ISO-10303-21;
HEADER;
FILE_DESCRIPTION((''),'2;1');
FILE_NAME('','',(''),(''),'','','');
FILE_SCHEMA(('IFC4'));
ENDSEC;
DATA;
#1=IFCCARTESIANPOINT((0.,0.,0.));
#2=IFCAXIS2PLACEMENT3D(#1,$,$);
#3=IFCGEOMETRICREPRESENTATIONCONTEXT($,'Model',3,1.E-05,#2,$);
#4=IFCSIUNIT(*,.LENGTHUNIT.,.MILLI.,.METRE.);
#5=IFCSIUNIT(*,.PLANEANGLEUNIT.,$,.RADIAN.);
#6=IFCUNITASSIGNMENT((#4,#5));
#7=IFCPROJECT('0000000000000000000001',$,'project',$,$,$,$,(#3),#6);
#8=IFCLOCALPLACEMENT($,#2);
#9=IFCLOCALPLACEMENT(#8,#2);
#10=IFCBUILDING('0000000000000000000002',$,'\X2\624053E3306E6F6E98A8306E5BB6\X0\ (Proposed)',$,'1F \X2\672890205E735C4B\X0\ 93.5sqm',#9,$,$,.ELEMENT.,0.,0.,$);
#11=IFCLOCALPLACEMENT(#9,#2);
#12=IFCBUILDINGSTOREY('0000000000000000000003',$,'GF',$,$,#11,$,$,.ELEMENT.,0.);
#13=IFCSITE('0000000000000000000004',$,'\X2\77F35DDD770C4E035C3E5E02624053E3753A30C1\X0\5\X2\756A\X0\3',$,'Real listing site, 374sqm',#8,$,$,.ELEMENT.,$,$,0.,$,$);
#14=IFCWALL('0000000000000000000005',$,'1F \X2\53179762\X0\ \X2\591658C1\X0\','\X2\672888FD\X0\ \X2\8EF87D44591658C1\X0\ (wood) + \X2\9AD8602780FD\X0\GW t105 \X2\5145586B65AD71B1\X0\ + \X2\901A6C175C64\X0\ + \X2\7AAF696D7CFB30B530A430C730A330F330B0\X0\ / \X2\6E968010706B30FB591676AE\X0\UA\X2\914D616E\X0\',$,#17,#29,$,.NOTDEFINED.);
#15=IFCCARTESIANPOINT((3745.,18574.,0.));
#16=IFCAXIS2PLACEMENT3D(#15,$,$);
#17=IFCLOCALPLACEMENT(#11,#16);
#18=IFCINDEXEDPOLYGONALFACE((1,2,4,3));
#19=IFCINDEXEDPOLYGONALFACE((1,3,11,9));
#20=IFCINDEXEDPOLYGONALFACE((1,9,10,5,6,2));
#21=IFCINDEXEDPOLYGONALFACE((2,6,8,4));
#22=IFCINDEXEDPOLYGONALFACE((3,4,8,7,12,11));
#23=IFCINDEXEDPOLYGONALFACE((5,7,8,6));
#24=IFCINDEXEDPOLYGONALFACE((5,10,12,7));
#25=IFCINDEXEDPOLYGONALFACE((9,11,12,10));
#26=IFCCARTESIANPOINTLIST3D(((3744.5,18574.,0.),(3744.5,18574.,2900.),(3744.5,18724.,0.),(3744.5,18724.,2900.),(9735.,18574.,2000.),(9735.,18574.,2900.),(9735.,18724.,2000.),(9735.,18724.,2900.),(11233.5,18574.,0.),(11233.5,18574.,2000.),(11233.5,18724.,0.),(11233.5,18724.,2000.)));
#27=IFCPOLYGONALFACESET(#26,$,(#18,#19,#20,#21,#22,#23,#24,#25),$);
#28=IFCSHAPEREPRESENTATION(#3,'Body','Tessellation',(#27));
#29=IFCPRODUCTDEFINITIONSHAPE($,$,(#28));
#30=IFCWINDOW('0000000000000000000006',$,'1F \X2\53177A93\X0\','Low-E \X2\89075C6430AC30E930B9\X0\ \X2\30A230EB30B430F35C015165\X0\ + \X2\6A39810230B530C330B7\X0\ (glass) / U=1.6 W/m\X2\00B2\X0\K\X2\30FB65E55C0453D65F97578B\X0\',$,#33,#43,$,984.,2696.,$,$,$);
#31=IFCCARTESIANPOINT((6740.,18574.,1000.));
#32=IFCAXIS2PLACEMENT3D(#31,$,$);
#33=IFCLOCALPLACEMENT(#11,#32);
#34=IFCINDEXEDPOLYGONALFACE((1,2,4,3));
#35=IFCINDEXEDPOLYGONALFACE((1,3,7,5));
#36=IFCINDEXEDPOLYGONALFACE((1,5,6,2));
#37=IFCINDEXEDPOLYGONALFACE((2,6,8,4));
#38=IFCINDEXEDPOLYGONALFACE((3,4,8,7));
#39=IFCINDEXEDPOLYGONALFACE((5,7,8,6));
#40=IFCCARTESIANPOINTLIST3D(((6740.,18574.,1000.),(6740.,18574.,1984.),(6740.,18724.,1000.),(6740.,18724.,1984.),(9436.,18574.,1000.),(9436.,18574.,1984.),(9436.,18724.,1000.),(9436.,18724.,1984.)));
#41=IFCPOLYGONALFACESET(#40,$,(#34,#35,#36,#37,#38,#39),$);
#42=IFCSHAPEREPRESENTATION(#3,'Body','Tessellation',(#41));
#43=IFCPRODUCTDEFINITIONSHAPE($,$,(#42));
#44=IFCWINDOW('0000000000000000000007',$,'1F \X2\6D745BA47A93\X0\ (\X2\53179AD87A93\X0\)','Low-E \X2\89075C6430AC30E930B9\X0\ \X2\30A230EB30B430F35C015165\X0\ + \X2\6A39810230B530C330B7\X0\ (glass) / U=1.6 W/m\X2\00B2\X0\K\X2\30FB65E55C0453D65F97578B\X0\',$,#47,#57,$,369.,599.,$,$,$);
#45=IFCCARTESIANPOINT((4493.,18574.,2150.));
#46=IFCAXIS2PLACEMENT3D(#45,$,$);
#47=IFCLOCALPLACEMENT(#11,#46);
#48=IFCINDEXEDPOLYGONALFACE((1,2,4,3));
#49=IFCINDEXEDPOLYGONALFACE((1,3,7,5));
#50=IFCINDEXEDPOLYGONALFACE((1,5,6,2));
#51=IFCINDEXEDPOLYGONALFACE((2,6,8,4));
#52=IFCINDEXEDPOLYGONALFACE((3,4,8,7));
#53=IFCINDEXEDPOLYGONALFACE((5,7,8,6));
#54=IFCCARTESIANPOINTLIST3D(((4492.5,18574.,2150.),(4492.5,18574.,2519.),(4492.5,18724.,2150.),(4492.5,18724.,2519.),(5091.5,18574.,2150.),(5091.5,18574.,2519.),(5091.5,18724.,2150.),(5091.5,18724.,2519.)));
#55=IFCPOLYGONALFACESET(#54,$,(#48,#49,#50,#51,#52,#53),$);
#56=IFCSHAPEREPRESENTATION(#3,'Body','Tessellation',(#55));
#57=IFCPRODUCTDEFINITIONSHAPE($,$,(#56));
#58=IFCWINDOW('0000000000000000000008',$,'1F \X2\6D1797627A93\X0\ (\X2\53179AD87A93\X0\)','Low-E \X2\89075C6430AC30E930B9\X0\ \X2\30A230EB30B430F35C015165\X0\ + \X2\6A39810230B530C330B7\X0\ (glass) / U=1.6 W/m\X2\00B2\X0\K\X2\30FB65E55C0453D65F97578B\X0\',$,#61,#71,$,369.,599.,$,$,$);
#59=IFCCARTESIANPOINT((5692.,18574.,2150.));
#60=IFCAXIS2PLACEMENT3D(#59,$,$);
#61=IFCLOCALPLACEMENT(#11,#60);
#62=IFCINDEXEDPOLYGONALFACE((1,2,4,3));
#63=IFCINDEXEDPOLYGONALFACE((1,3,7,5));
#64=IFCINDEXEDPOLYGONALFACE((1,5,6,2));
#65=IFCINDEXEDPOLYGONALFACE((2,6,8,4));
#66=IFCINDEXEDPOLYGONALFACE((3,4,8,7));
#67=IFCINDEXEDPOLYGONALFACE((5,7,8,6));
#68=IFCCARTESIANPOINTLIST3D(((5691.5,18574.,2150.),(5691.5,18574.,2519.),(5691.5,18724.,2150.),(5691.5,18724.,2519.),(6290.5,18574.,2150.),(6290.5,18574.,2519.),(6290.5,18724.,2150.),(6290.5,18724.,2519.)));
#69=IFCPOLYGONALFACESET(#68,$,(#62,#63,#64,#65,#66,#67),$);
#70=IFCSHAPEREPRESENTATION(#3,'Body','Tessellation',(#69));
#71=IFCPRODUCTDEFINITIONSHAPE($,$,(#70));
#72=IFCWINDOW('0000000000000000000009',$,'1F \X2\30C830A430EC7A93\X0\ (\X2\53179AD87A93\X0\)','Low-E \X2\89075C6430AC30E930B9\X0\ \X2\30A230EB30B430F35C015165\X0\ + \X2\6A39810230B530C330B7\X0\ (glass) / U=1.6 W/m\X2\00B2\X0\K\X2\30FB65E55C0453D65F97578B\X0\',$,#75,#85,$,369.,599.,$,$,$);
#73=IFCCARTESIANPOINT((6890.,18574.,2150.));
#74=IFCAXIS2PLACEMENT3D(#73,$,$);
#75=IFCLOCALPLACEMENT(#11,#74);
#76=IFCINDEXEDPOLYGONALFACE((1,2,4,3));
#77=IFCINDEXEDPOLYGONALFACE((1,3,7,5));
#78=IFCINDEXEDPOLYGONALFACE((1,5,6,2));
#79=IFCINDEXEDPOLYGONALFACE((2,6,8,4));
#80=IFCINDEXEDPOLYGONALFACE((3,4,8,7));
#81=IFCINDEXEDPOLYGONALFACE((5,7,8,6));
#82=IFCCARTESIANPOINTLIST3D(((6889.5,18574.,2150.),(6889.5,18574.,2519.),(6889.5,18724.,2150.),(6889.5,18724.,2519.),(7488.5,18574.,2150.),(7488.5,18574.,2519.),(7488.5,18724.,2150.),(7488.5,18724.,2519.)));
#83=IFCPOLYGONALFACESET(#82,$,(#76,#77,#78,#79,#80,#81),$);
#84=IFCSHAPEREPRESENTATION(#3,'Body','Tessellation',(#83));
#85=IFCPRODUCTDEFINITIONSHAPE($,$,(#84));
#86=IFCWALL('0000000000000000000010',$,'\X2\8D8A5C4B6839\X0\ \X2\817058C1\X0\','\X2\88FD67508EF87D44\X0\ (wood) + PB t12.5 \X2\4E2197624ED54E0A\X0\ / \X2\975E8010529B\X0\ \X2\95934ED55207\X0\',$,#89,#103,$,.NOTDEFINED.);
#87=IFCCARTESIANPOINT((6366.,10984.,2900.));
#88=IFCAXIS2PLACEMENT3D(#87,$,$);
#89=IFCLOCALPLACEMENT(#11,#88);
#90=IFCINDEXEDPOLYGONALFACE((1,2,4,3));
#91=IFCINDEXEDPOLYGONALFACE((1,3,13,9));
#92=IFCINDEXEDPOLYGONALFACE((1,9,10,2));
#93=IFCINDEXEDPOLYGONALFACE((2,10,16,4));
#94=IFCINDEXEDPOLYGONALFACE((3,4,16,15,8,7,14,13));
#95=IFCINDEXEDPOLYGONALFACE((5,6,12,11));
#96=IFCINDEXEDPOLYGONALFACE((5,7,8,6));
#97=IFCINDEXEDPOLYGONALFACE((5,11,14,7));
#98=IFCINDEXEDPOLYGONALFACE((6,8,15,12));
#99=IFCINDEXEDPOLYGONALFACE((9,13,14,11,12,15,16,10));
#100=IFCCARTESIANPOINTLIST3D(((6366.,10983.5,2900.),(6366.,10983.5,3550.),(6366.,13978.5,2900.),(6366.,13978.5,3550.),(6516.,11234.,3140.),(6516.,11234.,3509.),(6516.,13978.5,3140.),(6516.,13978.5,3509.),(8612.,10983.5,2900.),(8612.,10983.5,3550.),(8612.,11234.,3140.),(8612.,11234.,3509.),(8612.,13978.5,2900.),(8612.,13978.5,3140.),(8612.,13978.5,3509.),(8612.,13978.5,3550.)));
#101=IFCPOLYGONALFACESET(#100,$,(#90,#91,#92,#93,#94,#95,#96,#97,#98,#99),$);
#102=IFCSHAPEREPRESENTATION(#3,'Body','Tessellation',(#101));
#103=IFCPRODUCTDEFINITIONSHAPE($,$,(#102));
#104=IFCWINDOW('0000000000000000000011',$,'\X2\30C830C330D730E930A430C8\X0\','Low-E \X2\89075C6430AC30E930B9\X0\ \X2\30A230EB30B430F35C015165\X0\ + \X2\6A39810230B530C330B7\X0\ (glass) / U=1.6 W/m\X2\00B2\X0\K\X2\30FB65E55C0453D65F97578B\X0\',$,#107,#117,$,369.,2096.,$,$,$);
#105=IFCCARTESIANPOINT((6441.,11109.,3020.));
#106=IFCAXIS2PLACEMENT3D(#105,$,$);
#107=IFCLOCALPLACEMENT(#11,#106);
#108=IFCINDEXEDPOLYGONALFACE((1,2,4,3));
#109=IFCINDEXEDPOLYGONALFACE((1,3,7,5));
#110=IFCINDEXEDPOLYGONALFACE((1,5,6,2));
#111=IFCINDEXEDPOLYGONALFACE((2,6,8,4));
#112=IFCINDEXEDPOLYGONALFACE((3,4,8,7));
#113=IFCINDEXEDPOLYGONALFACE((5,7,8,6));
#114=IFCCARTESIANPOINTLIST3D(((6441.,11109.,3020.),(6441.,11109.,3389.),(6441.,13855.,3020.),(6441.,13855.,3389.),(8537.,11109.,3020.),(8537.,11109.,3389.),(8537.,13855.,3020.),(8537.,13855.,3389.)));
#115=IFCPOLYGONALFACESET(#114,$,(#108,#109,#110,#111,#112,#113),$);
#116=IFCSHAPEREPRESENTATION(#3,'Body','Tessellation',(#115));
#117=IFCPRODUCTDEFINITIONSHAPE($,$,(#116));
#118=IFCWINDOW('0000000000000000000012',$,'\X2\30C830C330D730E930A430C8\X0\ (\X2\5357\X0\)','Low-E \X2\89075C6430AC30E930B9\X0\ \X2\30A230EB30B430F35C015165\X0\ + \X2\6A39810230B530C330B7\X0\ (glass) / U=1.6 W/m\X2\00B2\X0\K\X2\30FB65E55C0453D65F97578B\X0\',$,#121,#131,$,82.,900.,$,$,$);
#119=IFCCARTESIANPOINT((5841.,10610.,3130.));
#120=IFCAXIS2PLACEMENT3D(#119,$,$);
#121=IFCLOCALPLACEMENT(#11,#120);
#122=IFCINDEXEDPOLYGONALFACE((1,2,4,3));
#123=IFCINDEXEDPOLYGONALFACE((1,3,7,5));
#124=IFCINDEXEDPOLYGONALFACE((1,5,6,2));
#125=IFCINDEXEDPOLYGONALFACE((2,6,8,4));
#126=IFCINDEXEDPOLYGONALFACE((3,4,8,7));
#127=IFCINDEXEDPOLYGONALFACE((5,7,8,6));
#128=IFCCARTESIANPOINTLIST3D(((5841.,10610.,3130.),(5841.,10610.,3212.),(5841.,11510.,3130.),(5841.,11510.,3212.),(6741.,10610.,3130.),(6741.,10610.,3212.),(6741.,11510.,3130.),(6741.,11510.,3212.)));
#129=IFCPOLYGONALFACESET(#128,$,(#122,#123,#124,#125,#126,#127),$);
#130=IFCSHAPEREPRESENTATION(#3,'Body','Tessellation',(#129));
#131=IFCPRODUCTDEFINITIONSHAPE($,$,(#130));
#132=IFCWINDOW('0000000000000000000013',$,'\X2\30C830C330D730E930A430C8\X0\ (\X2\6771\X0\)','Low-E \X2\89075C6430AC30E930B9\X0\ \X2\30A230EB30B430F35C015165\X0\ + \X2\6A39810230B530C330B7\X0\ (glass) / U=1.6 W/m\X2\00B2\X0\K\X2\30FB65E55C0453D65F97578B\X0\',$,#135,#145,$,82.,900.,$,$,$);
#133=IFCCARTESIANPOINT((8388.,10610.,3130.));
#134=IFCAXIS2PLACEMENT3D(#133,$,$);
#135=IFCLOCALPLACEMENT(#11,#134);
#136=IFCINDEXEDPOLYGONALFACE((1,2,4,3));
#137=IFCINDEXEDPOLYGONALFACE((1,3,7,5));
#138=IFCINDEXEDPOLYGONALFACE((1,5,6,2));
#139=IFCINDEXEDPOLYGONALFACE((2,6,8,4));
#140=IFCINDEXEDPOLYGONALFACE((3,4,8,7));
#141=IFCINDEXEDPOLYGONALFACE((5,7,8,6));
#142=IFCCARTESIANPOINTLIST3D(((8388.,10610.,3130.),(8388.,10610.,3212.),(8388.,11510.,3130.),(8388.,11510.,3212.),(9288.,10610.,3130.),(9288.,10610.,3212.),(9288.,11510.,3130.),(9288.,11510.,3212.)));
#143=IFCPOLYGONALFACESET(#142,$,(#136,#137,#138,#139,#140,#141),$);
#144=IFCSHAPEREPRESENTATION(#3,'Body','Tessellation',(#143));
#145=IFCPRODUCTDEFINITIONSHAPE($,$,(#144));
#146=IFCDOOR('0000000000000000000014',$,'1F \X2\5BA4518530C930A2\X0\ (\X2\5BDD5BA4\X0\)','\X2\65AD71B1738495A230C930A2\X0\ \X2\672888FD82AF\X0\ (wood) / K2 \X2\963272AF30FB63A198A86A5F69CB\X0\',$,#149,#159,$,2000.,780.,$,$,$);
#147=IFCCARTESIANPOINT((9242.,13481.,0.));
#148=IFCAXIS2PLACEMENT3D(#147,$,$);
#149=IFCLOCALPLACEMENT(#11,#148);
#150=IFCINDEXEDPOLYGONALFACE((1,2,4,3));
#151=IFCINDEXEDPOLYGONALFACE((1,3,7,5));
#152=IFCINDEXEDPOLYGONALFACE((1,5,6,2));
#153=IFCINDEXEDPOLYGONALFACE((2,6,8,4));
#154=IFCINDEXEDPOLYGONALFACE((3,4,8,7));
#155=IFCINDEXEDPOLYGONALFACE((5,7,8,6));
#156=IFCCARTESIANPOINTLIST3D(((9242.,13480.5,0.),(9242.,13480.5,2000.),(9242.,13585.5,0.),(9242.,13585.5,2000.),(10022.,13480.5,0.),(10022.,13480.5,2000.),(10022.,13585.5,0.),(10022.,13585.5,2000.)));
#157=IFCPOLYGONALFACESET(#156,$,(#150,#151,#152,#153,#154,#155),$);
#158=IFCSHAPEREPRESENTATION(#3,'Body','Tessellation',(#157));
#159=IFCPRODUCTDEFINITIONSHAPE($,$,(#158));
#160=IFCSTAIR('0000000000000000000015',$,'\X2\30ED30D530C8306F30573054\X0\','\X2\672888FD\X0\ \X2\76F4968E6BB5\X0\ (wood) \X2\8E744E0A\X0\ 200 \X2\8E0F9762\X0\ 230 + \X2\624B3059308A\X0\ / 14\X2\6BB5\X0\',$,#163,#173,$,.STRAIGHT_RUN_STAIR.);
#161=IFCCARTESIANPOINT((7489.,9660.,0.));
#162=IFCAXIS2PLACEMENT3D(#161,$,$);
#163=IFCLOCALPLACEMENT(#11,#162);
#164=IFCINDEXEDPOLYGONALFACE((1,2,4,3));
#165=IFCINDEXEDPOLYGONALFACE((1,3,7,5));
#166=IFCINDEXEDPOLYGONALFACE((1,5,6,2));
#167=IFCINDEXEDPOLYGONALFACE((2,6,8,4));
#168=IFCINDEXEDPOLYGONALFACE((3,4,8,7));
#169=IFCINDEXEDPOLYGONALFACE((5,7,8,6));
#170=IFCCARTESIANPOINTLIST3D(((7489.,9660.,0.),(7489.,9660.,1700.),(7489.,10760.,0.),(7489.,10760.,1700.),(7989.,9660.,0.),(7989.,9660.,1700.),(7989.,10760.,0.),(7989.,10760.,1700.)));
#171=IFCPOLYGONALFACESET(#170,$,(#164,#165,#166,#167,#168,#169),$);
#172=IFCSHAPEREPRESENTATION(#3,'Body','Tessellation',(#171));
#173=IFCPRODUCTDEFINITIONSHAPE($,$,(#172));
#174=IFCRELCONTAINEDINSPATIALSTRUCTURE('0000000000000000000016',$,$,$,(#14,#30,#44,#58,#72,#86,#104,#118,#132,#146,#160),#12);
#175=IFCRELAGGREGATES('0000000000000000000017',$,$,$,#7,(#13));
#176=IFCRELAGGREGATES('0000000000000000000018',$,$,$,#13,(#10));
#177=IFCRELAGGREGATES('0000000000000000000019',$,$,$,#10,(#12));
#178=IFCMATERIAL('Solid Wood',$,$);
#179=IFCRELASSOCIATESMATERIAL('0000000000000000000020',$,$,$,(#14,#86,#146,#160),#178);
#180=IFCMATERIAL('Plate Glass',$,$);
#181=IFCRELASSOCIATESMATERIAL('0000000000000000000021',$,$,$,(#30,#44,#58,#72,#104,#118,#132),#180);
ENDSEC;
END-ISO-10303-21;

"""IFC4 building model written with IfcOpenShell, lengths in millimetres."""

from ifc_helpers import new_model, si_unit, frame, frame_2d, origin, place, context, project, spatial, rectangle, extrude, material, element, fill, save


model = new_model("IFC4")

# Units and contexts
model_context = context("Model", 3, precision=1e-05, world=origin())
ifc_project = project(units=[si_unit("LENGTHUNIT", "METRE", prefix="MILLI"), si_unit("PLANEANGLEUNIT", "RADIAN")], contexts=[model_context])

# Site, building, storey
site_placement = place(None, origin())
site = spatial("IfcSite", under=ifc_project, at=site_placement, Name="石川県七尾市所口町チ5番3", ObjectType="Real listing site, 374sqm", CompositionType="ELEMENT", RefElevation=0.0)
building_placement = place(site_placement, origin())
building = spatial("IfcBuilding", under=site, at=building_placement, Name="所口の潮風の家 (Proposed)", ObjectType="1F 木造平屋 93.5sqm", CompositionType="ELEMENT", ElevationOfRefHeight=0.0, ElevationOfTerrain=0.0)
storey_placement = place(building_placement, origin())
storey = spatial("IfcBuildingStorey", under=building, at=storey_placement, Name="GF", CompositionType="ELEMENT", Elevation=0.0)

# Shared definitions
ifc_material_1 = material(Name="Solid Wood")

# Wall, openings, windows
wall_1_placement = place(storey_placement, frame((3745.0, 18574.0, 0.0)))
wall_1 = element("IfcWall", 1, at=wall_1_placement, inside=storey, material=ifc_material_1, Name="1F 北面 外壁", Description="木製 軸組外壁 (wood) + 高性能GW t105 充填断熱 + 通気層 + 窯業系サイディング / 準耐火・外皮UA配慮", PredefinedType="NOTDEFINED", context=model_context, shape_type="SweptSolid", body=[
    extrude(rectangle(XDim=7489.0, YDim=150.0, at=frame_2d((3744.0, 75.0))), frame((3745.0, 18574.0, 0.0)), (0.0, 0.0, 1.0), 2900.0),
])
opening_1_placement = place(storey_placement, frame((6740.0, 18574.0, 1000.0)))
opening_1 = element("IfcOpeningElement", 2, at=opening_1_placement, cuts=wall_1, PredefinedType="NOTDEFINED", context=model_context, shape_type="SweptSolid", body=[
    extrude(rectangle(XDim=2696.0, YDim=150.0, at=frame_2d((1348.0, 75.0))), frame((6740.0, 18574.0, 1000.0)), (0.0, 0.0, 1.0), 984.0),
])
opening_2_placement = place(storey_placement, frame((4493.0, 18574.0, 2150.0)))
opening_2 = element("IfcOpeningElement", 3, at=opening_2_placement, cuts=wall_1, PredefinedType="NOTDEFINED", context=model_context, shape_type="SweptSolid", body=[
    extrude(rectangle(XDim=599.0, YDim=150.0, at=frame_2d((299.0, 75.0))), frame((4493.0, 18574.0, 2150.0)), (0.0, 0.0, 1.0), 369.0),
])
opening_3_placement = place(storey_placement, frame((5692.0, 18574.0, 2150.0)))
opening_3 = element("IfcOpeningElement", 4, at=opening_3_placement, cuts=wall_1, PredefinedType="NOTDEFINED", context=model_context, shape_type="SweptSolid", body=[
    extrude(rectangle(XDim=599.0, YDim=150.0, at=frame_2d((299.0, 75.0))), frame((5692.0, 18574.0, 2150.0)), (0.0, 0.0, 1.0), 369.0),
])
opening_4_placement = place(storey_placement, frame((6890.0, 18574.0, 2150.0)))
opening_4 = element("IfcOpeningElement", 5, at=opening_4_placement, cuts=wall_1, PredefinedType="NOTDEFINED", context=model_context, shape_type="SweptSolid", body=[
    extrude(rectangle(XDim=599.0, YDim=150.0, at=frame_2d((299.0, 75.0))), frame((6890.0, 18574.0, 2150.0)), (0.0, 0.0, 1.0), 369.0),
])
ifc_material_2 = material(Name="Plate Glass")
window_1_placement = place(storey_placement, frame((6740.0, 18574.0, 1000.0)))
window_1 = element("IfcWindow", 6, at=window_1_placement, inside=storey, material=ifc_material_2, Name="1F 北窓", Description="Low-E 複層ガラス アルゴン封入 + 樹脂サッシ (glass) / U=1.6 W/m²K・日射取得型", OverallHeight=984.0, OverallWidth=2696.0, context=model_context, shape_type="SweptSolid", body=[
    extrude(rectangle(XDim=2696.0, YDim=150.0, at=frame_2d((1348.0, 75.0))), frame((6740.0, 18574.0, 1000.0)), (0.0, 0.0, 1.0), 984.0),
])
fill(opening_1, window_1)
window_2_placement = place(storey_placement, frame((4493.0, 18574.0, 2150.0)))
window_2 = element("IfcWindow", 7, at=window_2_placement, inside=storey, material=ifc_material_2, Name="1F 浴室窓 (北高窓)", Description="Low-E 複層ガラス アルゴン封入 + 樹脂サッシ (glass) / U=1.6 W/m²K・日射取得型", OverallHeight=369.0, OverallWidth=599.0, context=model_context, shape_type="SweptSolid", body=[
    extrude(rectangle(XDim=599.0, YDim=150.0, at=frame_2d((299.0, 75.0))), frame((4493.0, 18574.0, 2150.0)), (0.0, 0.0, 1.0), 369.0),
])
fill(opening_2, window_2)
window_3_placement = place(storey_placement, frame((5692.0, 18574.0, 2150.0)))
window_3 = element("IfcWindow", 8, at=window_3_placement, inside=storey, material=ifc_material_2, Name="1F 洗面窓 (北高窓)", Description="Low-E 複層ガラス アルゴン封入 + 樹脂サッシ (glass) / U=1.6 W/m²K・日射取得型", OverallHeight=369.0, OverallWidth=599.0, context=model_context, shape_type="SweptSolid", body=[
    extrude(rectangle(XDim=599.0, YDim=150.0, at=frame_2d((299.0, 75.0))), frame((5692.0, 18574.0, 2150.0)), (0.0, 0.0, 1.0), 369.0),
])
fill(opening_3, window_3)
window_4_placement = place(storey_placement, frame((6890.0, 18574.0, 2150.0)))
window_4 = element("IfcWindow", 9, at=window_4_placement, inside=storey, material=ifc_material_2, Name="1F トイレ窓 (北高窓)", Description="Low-E 複層ガラス アルゴン封入 + 樹脂サッシ (glass) / U=1.6 W/m²K・日射取得型", OverallHeight=369.0, OverallWidth=599.0, context=model_context, shape_type="SweptSolid", body=[
    extrude(rectangle(XDim=599.0, YDim=150.0, at=frame_2d((299.0, 75.0))), frame((6890.0, 18574.0, 2150.0)), (0.0, 0.0, 1.0), 369.0),
])
fill(opening_4, window_4)

# Wall, openings, windows
wall_2_placement = place(storey_placement, frame((6366.0, 10984.0, 2900.0)))
wall_2 = element("IfcWall", 10, at=wall_2_placement, inside=storey, material=ifc_material_1, Name="越屋根 腰壁", Description="製材軸組 (wood) + PB t12.5 両面仕上 / 非耐力 間仕切", PredefinedType="NOTDEFINED", context=model_context, shape_type="SweptSolid", body=[
    extrude(rectangle(XDim=2246.0, YDim=2995.0, at=frame_2d((1123.0, 1497.0))), frame((6366.0, 10984.0, 2900.0)), (0.0, 0.0, 1.0), 650.0),
])
opening_5_placement = place(storey_placement, frame((6441.0, 11109.0, 3020.0)))
opening_5 = element("IfcOpeningElement", 11, at=opening_5_placement, cuts=wall_2, PredefinedType="NOTDEFINED", context=model_context, shape_type="SweptSolid", body=[
    extrude(rectangle(XDim=2096.0, YDim=2746.0, at=frame_2d((1048.0, 1373.0))), frame((6441.0, 11109.0, 3020.0)), (0.0, 0.0, 1.0), 369.0),
])
opening_6_placement = place(storey_placement, frame((5841.0, 10610.0, 3130.0)))
opening_6 = element("IfcOpeningElement", 12, at=opening_6_placement, cuts=wall_2, PredefinedType="NOTDEFINED", context=model_context, shape_type="SweptSolid", body=[
    extrude(rectangle(XDim=900.0, YDim=900.0, at=frame_2d((450.0, 450.0))), frame((5841.0, 10610.0, 3130.0)), (0.0, 0.0, 1.0), 82.0),
])
opening_7_placement = place(storey_placement, frame((8388.0, 10610.0, 3130.0)))
opening_7 = element("IfcOpeningElement", 13, at=opening_7_placement, cuts=wall_2, PredefinedType="NOTDEFINED", context=model_context, shape_type="SweptSolid", body=[
    extrude(rectangle(XDim=900.0, YDim=900.0, at=frame_2d((450.0, 450.0))), frame((8388.0, 10610.0, 3130.0)), (0.0, 0.0, 1.0), 82.0),
])
window_5_placement = place(storey_placement, frame((6441.0, 11109.0, 3020.0)))
window_5 = element("IfcWindow", 14, at=window_5_placement, inside=storey, material=ifc_material_2, Name="トップライト", Description="Low-E 複層ガラス アルゴン封入 + 樹脂サッシ (glass) / U=1.6 W/m²K・日射取得型", OverallHeight=369.0, OverallWidth=2096.0, context=model_context, shape_type="SweptSolid", body=[
    extrude(rectangle(XDim=2096.0, YDim=2746.0, at=frame_2d((1048.0, 1373.0))), frame((6441.0, 11109.0, 3020.0)), (0.0, 0.0, 1.0), 369.0),
])
fill(opening_5, window_5)
window_6_placement = place(storey_placement, frame((5841.0, 10610.0, 3130.0)))
window_6 = element("IfcWindow", 15, at=window_6_placement, inside=storey, material=ifc_material_2, Name="トップライト (南)", Description="Low-E 複層ガラス アルゴン封入 + 樹脂サッシ (glass) / U=1.6 W/m²K・日射取得型", OverallHeight=82.0, OverallWidth=900.0, context=model_context, shape_type="SweptSolid", body=[
    extrude(rectangle(XDim=900.0, YDim=900.0, at=frame_2d((450.0, 450.0))), frame((5841.0, 10610.0, 3130.0)), (0.0, 0.0, 1.0), 82.0),
])
fill(opening_6, window_6)
window_7_placement = place(storey_placement, frame((8388.0, 10610.0, 3130.0)))
window_7 = element("IfcWindow", 16, at=window_7_placement, inside=storey, material=ifc_material_2, Name="トップライト (東)", Description="Low-E 複層ガラス アルゴン封入 + 樹脂サッシ (glass) / U=1.6 W/m²K・日射取得型", OverallHeight=82.0, OverallWidth=900.0, context=model_context, shape_type="SweptSolid", body=[
    extrude(rectangle(XDim=900.0, YDim=900.0, at=frame_2d((450.0, 450.0))), frame((8388.0, 10610.0, 3130.0)), (0.0, 0.0, 1.0), 82.0),
])
fill(opening_7, window_7)

# Door
door_1_placement = place(storey_placement, frame((9242.0, 13481.0, 0.0)))
element("IfcDoor", 17, at=door_1_placement, inside=storey, material=ifc_material_1, Name="1F 室内ドア (寝室)", Description="断熱玄関ドア 木製芯 (wood) / K2 防犯・採風機構", OverallHeight=2000.0, OverallWidth=780.0, context=model_context, shape_type="SweptSolid", body=[
    extrude(rectangle(XDim=780.0, YDim=105.0, at=frame_2d((390.0, 52.0))), frame((9242.0, 13481.0, 0.0)), (0.0, 0.0, 1.0), 2000.0),
])

# Stair
stair_placement = place(storey_placement, frame((7489.0, 9660.0, 0.0)))
element("IfcStair", 18, at=stair_placement, inside=storey, material=ifc_material_1, Name="ロフトはしご", Description="木製 直階段 (wood) 蹴上 200 踏面 230 + 手すり / 14段", PredefinedType="STRAIGHT_RUN_STAIR", context=model_context, shape_type="SweptSolid", body=[
    extrude(rectangle(XDim=500.0, YDim=1100.0, at=frame_2d((250.0, 550.0))), frame((7489.0, 9660.0, 0.0)), (0.0, 0.0, 1.0), 1700.0),
])

save(model, "model.ifc")
